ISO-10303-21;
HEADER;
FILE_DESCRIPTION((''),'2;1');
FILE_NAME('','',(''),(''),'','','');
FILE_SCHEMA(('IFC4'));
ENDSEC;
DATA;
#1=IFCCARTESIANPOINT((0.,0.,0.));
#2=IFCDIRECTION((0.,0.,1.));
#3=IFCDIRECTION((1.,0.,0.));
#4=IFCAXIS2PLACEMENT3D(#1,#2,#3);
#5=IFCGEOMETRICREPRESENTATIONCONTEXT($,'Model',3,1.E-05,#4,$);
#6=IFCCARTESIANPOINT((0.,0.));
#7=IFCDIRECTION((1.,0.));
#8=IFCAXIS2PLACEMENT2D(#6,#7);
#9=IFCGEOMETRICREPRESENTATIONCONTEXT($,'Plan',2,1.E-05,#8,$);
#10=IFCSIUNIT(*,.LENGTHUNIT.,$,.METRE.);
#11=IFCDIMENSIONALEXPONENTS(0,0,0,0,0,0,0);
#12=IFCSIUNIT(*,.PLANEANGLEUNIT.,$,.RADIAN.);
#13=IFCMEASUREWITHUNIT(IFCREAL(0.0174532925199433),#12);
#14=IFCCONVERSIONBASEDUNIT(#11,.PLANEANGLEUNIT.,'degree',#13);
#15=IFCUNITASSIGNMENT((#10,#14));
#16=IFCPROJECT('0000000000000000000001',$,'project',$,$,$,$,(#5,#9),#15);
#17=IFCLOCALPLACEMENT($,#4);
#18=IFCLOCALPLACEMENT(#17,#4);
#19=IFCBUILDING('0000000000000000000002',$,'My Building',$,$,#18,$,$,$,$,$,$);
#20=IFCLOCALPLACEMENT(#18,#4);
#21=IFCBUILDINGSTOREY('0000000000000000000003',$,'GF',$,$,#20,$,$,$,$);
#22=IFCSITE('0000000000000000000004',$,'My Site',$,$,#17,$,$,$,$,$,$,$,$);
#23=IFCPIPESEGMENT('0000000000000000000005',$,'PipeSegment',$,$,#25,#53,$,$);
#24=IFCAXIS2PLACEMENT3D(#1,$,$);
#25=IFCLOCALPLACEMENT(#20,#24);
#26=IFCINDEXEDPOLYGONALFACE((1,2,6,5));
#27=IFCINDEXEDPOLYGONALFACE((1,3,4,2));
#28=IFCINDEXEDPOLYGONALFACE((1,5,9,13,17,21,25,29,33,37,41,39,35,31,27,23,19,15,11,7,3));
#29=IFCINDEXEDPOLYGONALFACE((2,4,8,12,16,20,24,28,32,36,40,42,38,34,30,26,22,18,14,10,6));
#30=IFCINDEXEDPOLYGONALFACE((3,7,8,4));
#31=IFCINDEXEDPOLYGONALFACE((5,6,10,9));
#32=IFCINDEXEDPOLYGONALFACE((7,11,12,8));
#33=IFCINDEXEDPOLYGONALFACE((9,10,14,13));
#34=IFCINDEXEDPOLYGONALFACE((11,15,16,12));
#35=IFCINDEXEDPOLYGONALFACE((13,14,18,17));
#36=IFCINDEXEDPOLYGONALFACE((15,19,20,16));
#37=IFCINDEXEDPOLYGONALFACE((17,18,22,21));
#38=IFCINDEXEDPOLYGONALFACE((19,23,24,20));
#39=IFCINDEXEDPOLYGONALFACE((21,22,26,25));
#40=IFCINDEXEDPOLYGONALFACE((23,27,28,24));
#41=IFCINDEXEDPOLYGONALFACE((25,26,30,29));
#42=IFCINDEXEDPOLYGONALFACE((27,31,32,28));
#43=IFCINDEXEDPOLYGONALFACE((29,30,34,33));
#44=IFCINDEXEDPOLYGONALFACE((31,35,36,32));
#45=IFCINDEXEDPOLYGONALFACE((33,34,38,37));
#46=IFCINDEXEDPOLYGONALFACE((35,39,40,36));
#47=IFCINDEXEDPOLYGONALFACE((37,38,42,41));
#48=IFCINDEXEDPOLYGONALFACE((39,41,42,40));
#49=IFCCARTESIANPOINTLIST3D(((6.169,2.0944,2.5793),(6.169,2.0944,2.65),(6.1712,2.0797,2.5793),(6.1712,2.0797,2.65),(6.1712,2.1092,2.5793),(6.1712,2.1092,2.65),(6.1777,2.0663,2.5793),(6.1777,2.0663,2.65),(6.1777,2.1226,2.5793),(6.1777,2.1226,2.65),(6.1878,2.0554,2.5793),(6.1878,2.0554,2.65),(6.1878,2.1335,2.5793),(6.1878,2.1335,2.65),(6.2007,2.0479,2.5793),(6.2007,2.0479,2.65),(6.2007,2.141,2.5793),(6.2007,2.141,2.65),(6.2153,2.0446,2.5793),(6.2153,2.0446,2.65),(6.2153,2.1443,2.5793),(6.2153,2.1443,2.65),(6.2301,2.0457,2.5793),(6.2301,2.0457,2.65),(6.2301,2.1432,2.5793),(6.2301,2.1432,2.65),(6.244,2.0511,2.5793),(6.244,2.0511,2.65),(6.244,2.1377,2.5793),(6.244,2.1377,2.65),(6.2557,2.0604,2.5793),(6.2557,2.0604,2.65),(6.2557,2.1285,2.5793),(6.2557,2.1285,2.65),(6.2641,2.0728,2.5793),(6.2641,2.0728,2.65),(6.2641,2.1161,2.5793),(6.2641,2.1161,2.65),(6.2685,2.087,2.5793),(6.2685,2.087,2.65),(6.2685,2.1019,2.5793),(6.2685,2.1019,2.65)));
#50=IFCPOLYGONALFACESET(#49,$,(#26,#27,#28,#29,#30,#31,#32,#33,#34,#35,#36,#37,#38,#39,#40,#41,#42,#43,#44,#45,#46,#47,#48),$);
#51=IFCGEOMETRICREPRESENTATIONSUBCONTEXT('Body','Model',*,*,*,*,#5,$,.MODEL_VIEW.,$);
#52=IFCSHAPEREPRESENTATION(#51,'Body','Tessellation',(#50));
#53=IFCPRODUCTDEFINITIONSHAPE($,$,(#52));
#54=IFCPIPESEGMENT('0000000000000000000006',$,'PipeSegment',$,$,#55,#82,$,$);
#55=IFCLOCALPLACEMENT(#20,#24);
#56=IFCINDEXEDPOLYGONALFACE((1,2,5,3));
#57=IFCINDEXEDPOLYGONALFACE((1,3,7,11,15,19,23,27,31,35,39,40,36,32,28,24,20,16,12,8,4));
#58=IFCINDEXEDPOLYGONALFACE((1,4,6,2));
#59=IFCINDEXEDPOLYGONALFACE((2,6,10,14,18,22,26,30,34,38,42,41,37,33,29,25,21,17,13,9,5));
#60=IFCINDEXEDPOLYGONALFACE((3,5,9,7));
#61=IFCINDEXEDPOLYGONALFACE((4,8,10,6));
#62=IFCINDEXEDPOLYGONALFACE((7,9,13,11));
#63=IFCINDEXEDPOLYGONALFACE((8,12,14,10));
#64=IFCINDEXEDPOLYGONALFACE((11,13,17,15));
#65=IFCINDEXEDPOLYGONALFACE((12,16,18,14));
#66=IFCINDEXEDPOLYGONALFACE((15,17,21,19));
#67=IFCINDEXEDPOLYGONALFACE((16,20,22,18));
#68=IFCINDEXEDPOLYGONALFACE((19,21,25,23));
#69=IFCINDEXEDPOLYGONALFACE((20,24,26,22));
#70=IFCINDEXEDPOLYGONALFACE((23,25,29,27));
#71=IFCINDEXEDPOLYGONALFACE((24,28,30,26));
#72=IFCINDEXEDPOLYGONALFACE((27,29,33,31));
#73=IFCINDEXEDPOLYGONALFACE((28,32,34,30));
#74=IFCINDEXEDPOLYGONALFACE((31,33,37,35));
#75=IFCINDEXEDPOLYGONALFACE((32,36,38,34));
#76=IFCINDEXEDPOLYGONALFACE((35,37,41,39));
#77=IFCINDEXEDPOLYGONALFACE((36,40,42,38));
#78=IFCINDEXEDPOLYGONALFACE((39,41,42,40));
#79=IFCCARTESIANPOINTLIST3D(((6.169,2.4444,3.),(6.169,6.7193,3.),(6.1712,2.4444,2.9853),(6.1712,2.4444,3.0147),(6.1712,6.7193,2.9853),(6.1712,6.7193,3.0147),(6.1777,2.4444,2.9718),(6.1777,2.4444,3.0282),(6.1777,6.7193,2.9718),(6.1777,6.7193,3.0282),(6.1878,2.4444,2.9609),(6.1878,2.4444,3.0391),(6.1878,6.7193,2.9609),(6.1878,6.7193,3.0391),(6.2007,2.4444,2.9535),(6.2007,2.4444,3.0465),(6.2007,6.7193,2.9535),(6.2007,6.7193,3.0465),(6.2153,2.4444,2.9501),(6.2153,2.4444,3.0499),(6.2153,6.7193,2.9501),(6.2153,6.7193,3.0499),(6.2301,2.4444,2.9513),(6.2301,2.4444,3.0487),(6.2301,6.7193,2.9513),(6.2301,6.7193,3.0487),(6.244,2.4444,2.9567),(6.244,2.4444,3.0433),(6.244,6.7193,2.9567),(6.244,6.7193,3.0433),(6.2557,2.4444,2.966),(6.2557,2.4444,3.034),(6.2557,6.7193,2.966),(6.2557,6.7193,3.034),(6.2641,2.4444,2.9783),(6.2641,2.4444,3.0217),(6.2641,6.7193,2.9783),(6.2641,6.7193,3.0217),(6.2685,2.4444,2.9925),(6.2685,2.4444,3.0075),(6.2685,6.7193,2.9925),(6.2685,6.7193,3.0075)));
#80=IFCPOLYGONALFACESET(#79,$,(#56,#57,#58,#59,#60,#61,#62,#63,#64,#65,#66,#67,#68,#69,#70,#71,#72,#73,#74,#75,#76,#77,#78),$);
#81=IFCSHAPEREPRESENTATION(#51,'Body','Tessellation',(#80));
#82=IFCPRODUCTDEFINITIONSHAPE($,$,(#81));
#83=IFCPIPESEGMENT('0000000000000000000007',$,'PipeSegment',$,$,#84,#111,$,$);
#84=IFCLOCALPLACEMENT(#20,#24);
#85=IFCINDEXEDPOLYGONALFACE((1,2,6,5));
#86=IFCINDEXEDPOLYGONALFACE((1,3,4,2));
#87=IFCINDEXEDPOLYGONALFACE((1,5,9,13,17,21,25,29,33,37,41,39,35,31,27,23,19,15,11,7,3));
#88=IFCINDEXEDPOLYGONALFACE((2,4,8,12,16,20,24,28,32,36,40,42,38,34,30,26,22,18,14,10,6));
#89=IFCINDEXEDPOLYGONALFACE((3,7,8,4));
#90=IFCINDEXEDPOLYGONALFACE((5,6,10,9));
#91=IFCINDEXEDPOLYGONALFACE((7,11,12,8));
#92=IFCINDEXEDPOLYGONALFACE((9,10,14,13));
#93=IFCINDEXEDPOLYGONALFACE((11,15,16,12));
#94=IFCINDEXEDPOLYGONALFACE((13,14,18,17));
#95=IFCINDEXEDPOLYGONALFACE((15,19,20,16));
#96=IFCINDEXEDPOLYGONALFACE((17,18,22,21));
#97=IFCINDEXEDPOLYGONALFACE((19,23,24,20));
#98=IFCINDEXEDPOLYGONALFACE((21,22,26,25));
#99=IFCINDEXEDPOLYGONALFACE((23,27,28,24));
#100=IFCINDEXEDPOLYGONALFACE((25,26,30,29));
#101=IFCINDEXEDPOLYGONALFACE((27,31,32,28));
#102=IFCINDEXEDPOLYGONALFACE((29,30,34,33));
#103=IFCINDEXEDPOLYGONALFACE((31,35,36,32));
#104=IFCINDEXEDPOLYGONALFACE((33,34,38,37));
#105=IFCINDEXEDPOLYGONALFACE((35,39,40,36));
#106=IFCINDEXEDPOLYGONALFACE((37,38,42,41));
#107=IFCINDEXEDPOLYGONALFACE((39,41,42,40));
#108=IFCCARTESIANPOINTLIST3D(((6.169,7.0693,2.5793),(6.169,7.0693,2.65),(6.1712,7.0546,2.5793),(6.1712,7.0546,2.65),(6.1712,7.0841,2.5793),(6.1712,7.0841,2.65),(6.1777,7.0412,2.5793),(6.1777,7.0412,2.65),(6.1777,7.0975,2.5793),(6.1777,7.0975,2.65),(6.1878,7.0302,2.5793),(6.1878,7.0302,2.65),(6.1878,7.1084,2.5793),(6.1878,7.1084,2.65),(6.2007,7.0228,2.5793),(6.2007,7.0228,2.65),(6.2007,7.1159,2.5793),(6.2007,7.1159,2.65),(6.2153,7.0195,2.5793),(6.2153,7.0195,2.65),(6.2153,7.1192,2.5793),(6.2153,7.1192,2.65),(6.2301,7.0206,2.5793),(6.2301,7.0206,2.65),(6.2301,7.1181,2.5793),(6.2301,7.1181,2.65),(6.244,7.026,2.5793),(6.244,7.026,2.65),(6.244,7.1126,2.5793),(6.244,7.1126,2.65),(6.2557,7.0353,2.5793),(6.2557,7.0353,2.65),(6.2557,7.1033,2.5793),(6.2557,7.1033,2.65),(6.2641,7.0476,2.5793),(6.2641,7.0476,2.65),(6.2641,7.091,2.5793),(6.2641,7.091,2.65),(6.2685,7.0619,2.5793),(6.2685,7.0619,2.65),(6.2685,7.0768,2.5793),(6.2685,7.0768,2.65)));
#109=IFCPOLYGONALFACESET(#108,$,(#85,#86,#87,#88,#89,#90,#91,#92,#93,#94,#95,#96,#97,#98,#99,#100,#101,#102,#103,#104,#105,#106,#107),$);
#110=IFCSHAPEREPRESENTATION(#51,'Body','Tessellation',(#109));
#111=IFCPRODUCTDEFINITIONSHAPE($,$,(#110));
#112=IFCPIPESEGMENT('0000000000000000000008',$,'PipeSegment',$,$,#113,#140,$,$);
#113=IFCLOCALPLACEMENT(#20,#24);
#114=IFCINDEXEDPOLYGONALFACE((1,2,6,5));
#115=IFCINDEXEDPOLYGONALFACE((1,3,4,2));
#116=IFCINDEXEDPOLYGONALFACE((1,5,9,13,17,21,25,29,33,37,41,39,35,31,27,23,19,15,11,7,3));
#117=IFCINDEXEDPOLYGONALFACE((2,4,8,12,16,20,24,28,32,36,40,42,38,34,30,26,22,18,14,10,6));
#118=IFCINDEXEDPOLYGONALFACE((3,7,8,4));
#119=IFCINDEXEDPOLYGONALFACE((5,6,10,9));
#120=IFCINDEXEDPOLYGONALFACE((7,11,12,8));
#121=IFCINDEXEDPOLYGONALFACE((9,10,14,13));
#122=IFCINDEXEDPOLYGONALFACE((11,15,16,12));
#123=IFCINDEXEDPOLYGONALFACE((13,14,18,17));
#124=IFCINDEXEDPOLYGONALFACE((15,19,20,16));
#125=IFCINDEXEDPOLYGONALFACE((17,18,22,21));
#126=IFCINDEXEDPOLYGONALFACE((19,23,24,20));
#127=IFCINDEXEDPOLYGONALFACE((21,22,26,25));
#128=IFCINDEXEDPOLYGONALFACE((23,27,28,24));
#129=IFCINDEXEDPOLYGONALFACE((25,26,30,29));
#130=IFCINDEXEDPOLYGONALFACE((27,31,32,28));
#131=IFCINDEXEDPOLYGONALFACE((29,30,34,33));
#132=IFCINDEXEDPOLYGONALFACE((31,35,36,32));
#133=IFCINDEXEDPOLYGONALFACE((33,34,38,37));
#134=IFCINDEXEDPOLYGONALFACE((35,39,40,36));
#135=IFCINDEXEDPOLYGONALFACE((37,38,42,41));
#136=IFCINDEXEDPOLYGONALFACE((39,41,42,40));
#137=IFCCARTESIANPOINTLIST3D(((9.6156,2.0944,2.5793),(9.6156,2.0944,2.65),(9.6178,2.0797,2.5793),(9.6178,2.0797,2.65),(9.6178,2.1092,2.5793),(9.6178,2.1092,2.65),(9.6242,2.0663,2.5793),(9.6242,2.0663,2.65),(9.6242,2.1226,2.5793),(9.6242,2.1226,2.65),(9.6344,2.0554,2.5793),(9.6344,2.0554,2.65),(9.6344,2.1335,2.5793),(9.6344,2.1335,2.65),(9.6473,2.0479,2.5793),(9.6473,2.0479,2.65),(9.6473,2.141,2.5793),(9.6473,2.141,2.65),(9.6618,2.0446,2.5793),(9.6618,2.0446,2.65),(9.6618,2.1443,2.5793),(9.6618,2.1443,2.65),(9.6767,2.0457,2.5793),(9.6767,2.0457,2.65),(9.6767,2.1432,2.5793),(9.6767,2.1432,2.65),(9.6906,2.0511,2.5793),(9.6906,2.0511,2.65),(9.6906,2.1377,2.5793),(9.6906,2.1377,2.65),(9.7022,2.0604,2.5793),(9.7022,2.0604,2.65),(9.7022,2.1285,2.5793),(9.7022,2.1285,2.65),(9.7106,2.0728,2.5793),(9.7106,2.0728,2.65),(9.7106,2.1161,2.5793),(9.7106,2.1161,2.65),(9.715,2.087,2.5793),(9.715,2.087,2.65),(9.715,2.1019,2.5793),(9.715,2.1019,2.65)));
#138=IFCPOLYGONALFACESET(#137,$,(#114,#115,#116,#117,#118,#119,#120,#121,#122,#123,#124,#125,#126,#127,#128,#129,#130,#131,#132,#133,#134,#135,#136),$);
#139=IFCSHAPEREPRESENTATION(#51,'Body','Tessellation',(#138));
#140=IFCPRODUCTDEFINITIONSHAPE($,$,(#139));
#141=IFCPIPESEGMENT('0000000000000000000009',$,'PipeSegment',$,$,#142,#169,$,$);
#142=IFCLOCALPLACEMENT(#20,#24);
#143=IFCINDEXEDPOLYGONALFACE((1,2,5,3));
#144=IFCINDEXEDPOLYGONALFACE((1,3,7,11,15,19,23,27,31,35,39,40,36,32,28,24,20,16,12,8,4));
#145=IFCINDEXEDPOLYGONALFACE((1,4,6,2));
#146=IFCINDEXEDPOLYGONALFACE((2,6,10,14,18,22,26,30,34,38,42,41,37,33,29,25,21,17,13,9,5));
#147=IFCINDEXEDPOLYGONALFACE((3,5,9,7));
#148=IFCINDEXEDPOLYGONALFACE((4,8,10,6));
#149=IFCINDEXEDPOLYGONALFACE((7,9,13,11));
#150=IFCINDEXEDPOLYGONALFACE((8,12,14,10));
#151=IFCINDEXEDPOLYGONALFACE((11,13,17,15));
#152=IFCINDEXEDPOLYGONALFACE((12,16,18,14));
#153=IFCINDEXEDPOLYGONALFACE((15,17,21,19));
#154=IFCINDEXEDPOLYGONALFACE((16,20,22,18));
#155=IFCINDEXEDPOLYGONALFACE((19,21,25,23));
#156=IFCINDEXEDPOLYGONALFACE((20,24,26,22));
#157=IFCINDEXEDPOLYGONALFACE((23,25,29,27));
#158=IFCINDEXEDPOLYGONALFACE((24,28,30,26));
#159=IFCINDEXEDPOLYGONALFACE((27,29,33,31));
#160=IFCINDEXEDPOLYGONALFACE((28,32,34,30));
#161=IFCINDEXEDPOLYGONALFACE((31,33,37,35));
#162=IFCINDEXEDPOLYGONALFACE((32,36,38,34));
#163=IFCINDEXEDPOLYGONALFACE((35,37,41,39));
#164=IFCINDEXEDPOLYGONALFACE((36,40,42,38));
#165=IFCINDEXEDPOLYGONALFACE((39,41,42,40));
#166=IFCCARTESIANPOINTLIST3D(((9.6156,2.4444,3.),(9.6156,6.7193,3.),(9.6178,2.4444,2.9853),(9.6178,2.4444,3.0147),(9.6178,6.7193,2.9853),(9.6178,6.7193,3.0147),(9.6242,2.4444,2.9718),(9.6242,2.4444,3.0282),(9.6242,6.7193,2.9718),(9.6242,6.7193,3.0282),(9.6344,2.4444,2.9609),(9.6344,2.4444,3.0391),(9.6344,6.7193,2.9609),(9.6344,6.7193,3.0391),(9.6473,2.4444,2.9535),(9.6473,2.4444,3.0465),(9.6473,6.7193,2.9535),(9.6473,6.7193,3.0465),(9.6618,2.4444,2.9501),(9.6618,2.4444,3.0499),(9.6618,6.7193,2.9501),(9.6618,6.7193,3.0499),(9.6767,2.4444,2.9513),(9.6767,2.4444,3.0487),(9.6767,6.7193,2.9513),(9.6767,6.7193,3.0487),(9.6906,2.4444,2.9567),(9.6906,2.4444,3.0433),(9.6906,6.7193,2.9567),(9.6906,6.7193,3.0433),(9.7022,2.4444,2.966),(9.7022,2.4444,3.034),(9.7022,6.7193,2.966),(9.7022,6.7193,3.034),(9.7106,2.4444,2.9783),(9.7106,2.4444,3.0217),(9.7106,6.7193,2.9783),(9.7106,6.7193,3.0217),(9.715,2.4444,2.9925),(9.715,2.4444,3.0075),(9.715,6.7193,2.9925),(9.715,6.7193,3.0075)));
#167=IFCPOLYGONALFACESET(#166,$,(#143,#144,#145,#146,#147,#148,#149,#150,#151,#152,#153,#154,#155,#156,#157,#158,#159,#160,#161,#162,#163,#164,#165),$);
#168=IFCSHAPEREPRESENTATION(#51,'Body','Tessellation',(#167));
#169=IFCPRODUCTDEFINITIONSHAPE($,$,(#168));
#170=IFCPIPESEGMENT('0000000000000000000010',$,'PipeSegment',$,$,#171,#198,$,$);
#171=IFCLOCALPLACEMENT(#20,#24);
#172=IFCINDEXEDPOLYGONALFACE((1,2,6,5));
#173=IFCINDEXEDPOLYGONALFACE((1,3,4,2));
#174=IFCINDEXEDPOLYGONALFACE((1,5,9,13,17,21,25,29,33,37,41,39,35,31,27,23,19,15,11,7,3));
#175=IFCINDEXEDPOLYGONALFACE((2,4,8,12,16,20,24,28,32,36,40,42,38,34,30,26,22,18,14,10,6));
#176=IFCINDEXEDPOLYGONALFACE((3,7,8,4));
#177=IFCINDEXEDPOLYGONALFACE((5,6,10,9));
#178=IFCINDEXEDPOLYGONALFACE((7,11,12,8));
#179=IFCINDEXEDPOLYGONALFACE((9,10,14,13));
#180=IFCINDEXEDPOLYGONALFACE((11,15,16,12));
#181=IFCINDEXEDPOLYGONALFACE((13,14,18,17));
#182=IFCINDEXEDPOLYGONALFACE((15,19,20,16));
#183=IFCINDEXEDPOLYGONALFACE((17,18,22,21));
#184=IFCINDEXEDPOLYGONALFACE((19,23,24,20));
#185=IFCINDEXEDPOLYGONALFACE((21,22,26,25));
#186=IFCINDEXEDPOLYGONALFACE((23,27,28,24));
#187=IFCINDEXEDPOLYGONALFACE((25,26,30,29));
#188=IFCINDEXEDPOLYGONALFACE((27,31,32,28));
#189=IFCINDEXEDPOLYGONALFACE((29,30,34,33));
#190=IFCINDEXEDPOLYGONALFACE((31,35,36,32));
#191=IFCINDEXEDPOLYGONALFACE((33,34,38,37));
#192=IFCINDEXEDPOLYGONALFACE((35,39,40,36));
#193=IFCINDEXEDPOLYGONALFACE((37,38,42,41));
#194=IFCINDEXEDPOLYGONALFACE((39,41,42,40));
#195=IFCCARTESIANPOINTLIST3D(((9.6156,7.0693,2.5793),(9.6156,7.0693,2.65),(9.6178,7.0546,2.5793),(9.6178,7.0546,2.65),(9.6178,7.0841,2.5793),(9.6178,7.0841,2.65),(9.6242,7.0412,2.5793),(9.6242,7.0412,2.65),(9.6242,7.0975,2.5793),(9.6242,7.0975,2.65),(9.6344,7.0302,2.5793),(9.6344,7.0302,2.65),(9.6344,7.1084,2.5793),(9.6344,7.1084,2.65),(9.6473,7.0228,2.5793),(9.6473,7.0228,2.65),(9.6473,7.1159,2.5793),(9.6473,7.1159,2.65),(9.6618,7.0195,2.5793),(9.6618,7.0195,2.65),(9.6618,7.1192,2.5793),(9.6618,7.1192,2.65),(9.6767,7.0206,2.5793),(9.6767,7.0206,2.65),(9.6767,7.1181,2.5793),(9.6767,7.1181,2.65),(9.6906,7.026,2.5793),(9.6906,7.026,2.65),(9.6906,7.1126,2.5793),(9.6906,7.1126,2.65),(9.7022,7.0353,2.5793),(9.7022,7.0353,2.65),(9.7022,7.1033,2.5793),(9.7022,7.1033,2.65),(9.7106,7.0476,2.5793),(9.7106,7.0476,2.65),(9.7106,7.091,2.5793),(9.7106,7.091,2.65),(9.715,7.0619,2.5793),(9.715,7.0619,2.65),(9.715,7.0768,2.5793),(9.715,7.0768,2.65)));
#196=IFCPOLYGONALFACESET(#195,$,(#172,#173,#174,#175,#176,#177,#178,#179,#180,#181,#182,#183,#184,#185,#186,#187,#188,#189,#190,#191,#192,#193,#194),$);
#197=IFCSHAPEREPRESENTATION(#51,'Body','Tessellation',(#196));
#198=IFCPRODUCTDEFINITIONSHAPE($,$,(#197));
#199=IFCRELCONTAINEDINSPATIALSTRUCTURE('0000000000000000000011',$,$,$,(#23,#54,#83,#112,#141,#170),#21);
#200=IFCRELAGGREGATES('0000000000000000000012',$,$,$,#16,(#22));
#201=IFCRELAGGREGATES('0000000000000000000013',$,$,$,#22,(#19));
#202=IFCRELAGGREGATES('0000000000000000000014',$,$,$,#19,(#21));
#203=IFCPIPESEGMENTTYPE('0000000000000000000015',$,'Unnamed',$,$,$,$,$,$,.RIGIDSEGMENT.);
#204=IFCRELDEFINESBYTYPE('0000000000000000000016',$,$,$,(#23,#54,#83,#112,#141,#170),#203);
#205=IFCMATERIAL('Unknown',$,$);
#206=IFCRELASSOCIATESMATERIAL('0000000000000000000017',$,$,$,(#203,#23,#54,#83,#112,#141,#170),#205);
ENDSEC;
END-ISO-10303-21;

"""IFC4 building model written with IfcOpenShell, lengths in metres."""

from ifc_helpers import new_model, entity, si_unit, converted_unit, frame, origin_with_axes, origin_2d_with_axis, place, context, subcontext, project, spatial, circle, extrude, material, material_profile, profile_set, profile_usage, type_object, element, save


model = new_model("IFC4")

# Units and contexts
model_context = context("Model", 3, precision=1e-05, world=origin_with_axes())
plan_context = context("Plan", 2, precision=1e-05, world=origin_2d_with_axis())
body_context = subcontext(model_context, "Body", "Model", "MODEL_VIEW")
ifc_project = project(units=[si_unit("LENGTHUNIT", "METRE"), converted_unit("PLANEANGLEUNIT", "degree", entity("IfcReal", 0.0174532925199433), si_unit("PLANEANGLEUNIT", "RADIAN"), dimensions=[0, 0, 0, 0, 0, 0, 0])], contexts=[model_context, plan_context])

# Site, building, storey
site_placement = place(None, origin_with_axes())
site = spatial("IfcSite", under=ifc_project, at=site_placement, Name="My Site")
building_placement = place(site_placement, origin_with_axes())
building = spatial("IfcBuilding", under=site, at=building_placement, Name="My Building")
storey_placement = place(building_placement, origin_with_axes())
storey = spatial("IfcBuildingStorey", under=building, at=storey_placement, Name="GF")

# Pipe segments
ifc_material = material(Name="Unknown")
ifc_material_profile = material_profile(ifc_material, circle(Radius=0.05))
ifc_profile_set = profile_set([ifc_material_profile])
ifc_profile_usage_1 = profile_usage(ifc_profile_set, cardinal=5)
pipe_segment_type = type_object("IfcPipeSegmentType", Name="Unnamed", PredefinedType="RIGIDSEGMENT", material=ifc_profile_set)
pipe_segment_1_placement = place(storey_placement, frame((6.219, 2.0944, 2.65), z_axis=(0.0, 0.0, -1.0), x_axis=(-1.0, 0.0, 0.0)))
element("IfcPipeSegment", 1, at=pipe_segment_1_placement, inside=storey, type_object=pipe_segment_type, material=ifc_profile_usage_1, Name="PipeSegment", context=body_context, shape_type="SweptSolid", body=[
    extrude(circle(Radius=0.05), origin_with_axes(), (0.0, 0.0, 1.0), 0.0707),
])
ifc_profile_usage_2 = profile_usage(ifc_profile_set, cardinal=5)
pipe_segment_2_placement = place(storey_placement, frame((6.219, 2.4444, 3.0), z_axis=(0.0, 1.0, 0.0), x_axis=(-1.0, 0.0, 0.0)))
element("IfcPipeSegment", 2, at=pipe_segment_2_placement, inside=storey, type_object=pipe_segment_type, material=ifc_profile_usage_2, Name="PipeSegment", context=body_context, shape_type="SweptSolid", body=[
    extrude(circle(Radius=0.05), origin_with_axes(), (0.0, 0.0, 1.0), 4.2749),
])
ifc_profile_usage_3 = profile_usage(ifc_profile_set, cardinal=5)
pipe_segment_3_placement = place(storey_placement, frame((6.219, 7.0693, 2.65), z_axis=(0.0, 0.0, -1.0), x_axis=(-1.0, 0.0, 0.0)))
element("IfcPipeSegment", 3, at=pipe_segment_3_placement, inside=storey, type_object=pipe_segment_type, material=ifc_profile_usage_3, Name="PipeSegment", context=body_context, shape_type="SweptSolid", body=[
    extrude(circle(Radius=0.05), origin_with_axes(), (0.0, 0.0, 1.0), 0.0707),
])
ifc_profile_usage_4 = profile_usage(ifc_profile_set, cardinal=5)
pipe_segment_4_placement = place(storey_placement, frame((9.6656, 2.0944, 2.65), z_axis=(0.0, 0.0, -1.0), x_axis=(-1.0, 0.0, 0.0)))
element("IfcPipeSegment", 4, at=pipe_segment_4_placement, inside=storey, type_object=pipe_segment_type, material=ifc_profile_usage_4, Name="PipeSegment", context=body_context, shape_type="SweptSolid", body=[
    extrude(circle(Radius=0.05), origin_with_axes(), (0.0, 0.0, 1.0), 0.0707),
])
ifc_profile_usage_5 = profile_usage(ifc_profile_set, cardinal=5)
pipe_segment_5_placement = place(storey_placement, frame((9.6656, 2.4444, 3.0), z_axis=(0.0, 1.0, 0.0), x_axis=(-1.0, 0.0, 0.0)))
element("IfcPipeSegment", 5, at=pipe_segment_5_placement, inside=storey, type_object=pipe_segment_type, material=ifc_profile_usage_5, Name="PipeSegment", context=body_context, shape_type="SweptSolid", body=[
    extrude(circle(Radius=0.05), origin_with_axes(), (0.0, 0.0, 1.0), 4.2749),
])
ifc_profile_usage_6 = profile_usage(ifc_profile_set, cardinal=5)
pipe_segment_6_placement = place(storey_placement, frame((9.6656, 7.0693, 2.65), z_axis=(0.0, 0.0, -1.0), x_axis=(-1.0, 0.0, 0.0)))
element("IfcPipeSegment", 6, at=pipe_segment_6_placement, inside=storey, type_object=pipe_segment_type, material=ifc_profile_usage_6, Name="PipeSegment", context=body_context, shape_type="SweptSolid", body=[
    extrude(circle(Radius=0.05), origin_with_axes(), (0.0, 0.0, 1.0), 0.0707),
])

save(model, "model.ifc")
